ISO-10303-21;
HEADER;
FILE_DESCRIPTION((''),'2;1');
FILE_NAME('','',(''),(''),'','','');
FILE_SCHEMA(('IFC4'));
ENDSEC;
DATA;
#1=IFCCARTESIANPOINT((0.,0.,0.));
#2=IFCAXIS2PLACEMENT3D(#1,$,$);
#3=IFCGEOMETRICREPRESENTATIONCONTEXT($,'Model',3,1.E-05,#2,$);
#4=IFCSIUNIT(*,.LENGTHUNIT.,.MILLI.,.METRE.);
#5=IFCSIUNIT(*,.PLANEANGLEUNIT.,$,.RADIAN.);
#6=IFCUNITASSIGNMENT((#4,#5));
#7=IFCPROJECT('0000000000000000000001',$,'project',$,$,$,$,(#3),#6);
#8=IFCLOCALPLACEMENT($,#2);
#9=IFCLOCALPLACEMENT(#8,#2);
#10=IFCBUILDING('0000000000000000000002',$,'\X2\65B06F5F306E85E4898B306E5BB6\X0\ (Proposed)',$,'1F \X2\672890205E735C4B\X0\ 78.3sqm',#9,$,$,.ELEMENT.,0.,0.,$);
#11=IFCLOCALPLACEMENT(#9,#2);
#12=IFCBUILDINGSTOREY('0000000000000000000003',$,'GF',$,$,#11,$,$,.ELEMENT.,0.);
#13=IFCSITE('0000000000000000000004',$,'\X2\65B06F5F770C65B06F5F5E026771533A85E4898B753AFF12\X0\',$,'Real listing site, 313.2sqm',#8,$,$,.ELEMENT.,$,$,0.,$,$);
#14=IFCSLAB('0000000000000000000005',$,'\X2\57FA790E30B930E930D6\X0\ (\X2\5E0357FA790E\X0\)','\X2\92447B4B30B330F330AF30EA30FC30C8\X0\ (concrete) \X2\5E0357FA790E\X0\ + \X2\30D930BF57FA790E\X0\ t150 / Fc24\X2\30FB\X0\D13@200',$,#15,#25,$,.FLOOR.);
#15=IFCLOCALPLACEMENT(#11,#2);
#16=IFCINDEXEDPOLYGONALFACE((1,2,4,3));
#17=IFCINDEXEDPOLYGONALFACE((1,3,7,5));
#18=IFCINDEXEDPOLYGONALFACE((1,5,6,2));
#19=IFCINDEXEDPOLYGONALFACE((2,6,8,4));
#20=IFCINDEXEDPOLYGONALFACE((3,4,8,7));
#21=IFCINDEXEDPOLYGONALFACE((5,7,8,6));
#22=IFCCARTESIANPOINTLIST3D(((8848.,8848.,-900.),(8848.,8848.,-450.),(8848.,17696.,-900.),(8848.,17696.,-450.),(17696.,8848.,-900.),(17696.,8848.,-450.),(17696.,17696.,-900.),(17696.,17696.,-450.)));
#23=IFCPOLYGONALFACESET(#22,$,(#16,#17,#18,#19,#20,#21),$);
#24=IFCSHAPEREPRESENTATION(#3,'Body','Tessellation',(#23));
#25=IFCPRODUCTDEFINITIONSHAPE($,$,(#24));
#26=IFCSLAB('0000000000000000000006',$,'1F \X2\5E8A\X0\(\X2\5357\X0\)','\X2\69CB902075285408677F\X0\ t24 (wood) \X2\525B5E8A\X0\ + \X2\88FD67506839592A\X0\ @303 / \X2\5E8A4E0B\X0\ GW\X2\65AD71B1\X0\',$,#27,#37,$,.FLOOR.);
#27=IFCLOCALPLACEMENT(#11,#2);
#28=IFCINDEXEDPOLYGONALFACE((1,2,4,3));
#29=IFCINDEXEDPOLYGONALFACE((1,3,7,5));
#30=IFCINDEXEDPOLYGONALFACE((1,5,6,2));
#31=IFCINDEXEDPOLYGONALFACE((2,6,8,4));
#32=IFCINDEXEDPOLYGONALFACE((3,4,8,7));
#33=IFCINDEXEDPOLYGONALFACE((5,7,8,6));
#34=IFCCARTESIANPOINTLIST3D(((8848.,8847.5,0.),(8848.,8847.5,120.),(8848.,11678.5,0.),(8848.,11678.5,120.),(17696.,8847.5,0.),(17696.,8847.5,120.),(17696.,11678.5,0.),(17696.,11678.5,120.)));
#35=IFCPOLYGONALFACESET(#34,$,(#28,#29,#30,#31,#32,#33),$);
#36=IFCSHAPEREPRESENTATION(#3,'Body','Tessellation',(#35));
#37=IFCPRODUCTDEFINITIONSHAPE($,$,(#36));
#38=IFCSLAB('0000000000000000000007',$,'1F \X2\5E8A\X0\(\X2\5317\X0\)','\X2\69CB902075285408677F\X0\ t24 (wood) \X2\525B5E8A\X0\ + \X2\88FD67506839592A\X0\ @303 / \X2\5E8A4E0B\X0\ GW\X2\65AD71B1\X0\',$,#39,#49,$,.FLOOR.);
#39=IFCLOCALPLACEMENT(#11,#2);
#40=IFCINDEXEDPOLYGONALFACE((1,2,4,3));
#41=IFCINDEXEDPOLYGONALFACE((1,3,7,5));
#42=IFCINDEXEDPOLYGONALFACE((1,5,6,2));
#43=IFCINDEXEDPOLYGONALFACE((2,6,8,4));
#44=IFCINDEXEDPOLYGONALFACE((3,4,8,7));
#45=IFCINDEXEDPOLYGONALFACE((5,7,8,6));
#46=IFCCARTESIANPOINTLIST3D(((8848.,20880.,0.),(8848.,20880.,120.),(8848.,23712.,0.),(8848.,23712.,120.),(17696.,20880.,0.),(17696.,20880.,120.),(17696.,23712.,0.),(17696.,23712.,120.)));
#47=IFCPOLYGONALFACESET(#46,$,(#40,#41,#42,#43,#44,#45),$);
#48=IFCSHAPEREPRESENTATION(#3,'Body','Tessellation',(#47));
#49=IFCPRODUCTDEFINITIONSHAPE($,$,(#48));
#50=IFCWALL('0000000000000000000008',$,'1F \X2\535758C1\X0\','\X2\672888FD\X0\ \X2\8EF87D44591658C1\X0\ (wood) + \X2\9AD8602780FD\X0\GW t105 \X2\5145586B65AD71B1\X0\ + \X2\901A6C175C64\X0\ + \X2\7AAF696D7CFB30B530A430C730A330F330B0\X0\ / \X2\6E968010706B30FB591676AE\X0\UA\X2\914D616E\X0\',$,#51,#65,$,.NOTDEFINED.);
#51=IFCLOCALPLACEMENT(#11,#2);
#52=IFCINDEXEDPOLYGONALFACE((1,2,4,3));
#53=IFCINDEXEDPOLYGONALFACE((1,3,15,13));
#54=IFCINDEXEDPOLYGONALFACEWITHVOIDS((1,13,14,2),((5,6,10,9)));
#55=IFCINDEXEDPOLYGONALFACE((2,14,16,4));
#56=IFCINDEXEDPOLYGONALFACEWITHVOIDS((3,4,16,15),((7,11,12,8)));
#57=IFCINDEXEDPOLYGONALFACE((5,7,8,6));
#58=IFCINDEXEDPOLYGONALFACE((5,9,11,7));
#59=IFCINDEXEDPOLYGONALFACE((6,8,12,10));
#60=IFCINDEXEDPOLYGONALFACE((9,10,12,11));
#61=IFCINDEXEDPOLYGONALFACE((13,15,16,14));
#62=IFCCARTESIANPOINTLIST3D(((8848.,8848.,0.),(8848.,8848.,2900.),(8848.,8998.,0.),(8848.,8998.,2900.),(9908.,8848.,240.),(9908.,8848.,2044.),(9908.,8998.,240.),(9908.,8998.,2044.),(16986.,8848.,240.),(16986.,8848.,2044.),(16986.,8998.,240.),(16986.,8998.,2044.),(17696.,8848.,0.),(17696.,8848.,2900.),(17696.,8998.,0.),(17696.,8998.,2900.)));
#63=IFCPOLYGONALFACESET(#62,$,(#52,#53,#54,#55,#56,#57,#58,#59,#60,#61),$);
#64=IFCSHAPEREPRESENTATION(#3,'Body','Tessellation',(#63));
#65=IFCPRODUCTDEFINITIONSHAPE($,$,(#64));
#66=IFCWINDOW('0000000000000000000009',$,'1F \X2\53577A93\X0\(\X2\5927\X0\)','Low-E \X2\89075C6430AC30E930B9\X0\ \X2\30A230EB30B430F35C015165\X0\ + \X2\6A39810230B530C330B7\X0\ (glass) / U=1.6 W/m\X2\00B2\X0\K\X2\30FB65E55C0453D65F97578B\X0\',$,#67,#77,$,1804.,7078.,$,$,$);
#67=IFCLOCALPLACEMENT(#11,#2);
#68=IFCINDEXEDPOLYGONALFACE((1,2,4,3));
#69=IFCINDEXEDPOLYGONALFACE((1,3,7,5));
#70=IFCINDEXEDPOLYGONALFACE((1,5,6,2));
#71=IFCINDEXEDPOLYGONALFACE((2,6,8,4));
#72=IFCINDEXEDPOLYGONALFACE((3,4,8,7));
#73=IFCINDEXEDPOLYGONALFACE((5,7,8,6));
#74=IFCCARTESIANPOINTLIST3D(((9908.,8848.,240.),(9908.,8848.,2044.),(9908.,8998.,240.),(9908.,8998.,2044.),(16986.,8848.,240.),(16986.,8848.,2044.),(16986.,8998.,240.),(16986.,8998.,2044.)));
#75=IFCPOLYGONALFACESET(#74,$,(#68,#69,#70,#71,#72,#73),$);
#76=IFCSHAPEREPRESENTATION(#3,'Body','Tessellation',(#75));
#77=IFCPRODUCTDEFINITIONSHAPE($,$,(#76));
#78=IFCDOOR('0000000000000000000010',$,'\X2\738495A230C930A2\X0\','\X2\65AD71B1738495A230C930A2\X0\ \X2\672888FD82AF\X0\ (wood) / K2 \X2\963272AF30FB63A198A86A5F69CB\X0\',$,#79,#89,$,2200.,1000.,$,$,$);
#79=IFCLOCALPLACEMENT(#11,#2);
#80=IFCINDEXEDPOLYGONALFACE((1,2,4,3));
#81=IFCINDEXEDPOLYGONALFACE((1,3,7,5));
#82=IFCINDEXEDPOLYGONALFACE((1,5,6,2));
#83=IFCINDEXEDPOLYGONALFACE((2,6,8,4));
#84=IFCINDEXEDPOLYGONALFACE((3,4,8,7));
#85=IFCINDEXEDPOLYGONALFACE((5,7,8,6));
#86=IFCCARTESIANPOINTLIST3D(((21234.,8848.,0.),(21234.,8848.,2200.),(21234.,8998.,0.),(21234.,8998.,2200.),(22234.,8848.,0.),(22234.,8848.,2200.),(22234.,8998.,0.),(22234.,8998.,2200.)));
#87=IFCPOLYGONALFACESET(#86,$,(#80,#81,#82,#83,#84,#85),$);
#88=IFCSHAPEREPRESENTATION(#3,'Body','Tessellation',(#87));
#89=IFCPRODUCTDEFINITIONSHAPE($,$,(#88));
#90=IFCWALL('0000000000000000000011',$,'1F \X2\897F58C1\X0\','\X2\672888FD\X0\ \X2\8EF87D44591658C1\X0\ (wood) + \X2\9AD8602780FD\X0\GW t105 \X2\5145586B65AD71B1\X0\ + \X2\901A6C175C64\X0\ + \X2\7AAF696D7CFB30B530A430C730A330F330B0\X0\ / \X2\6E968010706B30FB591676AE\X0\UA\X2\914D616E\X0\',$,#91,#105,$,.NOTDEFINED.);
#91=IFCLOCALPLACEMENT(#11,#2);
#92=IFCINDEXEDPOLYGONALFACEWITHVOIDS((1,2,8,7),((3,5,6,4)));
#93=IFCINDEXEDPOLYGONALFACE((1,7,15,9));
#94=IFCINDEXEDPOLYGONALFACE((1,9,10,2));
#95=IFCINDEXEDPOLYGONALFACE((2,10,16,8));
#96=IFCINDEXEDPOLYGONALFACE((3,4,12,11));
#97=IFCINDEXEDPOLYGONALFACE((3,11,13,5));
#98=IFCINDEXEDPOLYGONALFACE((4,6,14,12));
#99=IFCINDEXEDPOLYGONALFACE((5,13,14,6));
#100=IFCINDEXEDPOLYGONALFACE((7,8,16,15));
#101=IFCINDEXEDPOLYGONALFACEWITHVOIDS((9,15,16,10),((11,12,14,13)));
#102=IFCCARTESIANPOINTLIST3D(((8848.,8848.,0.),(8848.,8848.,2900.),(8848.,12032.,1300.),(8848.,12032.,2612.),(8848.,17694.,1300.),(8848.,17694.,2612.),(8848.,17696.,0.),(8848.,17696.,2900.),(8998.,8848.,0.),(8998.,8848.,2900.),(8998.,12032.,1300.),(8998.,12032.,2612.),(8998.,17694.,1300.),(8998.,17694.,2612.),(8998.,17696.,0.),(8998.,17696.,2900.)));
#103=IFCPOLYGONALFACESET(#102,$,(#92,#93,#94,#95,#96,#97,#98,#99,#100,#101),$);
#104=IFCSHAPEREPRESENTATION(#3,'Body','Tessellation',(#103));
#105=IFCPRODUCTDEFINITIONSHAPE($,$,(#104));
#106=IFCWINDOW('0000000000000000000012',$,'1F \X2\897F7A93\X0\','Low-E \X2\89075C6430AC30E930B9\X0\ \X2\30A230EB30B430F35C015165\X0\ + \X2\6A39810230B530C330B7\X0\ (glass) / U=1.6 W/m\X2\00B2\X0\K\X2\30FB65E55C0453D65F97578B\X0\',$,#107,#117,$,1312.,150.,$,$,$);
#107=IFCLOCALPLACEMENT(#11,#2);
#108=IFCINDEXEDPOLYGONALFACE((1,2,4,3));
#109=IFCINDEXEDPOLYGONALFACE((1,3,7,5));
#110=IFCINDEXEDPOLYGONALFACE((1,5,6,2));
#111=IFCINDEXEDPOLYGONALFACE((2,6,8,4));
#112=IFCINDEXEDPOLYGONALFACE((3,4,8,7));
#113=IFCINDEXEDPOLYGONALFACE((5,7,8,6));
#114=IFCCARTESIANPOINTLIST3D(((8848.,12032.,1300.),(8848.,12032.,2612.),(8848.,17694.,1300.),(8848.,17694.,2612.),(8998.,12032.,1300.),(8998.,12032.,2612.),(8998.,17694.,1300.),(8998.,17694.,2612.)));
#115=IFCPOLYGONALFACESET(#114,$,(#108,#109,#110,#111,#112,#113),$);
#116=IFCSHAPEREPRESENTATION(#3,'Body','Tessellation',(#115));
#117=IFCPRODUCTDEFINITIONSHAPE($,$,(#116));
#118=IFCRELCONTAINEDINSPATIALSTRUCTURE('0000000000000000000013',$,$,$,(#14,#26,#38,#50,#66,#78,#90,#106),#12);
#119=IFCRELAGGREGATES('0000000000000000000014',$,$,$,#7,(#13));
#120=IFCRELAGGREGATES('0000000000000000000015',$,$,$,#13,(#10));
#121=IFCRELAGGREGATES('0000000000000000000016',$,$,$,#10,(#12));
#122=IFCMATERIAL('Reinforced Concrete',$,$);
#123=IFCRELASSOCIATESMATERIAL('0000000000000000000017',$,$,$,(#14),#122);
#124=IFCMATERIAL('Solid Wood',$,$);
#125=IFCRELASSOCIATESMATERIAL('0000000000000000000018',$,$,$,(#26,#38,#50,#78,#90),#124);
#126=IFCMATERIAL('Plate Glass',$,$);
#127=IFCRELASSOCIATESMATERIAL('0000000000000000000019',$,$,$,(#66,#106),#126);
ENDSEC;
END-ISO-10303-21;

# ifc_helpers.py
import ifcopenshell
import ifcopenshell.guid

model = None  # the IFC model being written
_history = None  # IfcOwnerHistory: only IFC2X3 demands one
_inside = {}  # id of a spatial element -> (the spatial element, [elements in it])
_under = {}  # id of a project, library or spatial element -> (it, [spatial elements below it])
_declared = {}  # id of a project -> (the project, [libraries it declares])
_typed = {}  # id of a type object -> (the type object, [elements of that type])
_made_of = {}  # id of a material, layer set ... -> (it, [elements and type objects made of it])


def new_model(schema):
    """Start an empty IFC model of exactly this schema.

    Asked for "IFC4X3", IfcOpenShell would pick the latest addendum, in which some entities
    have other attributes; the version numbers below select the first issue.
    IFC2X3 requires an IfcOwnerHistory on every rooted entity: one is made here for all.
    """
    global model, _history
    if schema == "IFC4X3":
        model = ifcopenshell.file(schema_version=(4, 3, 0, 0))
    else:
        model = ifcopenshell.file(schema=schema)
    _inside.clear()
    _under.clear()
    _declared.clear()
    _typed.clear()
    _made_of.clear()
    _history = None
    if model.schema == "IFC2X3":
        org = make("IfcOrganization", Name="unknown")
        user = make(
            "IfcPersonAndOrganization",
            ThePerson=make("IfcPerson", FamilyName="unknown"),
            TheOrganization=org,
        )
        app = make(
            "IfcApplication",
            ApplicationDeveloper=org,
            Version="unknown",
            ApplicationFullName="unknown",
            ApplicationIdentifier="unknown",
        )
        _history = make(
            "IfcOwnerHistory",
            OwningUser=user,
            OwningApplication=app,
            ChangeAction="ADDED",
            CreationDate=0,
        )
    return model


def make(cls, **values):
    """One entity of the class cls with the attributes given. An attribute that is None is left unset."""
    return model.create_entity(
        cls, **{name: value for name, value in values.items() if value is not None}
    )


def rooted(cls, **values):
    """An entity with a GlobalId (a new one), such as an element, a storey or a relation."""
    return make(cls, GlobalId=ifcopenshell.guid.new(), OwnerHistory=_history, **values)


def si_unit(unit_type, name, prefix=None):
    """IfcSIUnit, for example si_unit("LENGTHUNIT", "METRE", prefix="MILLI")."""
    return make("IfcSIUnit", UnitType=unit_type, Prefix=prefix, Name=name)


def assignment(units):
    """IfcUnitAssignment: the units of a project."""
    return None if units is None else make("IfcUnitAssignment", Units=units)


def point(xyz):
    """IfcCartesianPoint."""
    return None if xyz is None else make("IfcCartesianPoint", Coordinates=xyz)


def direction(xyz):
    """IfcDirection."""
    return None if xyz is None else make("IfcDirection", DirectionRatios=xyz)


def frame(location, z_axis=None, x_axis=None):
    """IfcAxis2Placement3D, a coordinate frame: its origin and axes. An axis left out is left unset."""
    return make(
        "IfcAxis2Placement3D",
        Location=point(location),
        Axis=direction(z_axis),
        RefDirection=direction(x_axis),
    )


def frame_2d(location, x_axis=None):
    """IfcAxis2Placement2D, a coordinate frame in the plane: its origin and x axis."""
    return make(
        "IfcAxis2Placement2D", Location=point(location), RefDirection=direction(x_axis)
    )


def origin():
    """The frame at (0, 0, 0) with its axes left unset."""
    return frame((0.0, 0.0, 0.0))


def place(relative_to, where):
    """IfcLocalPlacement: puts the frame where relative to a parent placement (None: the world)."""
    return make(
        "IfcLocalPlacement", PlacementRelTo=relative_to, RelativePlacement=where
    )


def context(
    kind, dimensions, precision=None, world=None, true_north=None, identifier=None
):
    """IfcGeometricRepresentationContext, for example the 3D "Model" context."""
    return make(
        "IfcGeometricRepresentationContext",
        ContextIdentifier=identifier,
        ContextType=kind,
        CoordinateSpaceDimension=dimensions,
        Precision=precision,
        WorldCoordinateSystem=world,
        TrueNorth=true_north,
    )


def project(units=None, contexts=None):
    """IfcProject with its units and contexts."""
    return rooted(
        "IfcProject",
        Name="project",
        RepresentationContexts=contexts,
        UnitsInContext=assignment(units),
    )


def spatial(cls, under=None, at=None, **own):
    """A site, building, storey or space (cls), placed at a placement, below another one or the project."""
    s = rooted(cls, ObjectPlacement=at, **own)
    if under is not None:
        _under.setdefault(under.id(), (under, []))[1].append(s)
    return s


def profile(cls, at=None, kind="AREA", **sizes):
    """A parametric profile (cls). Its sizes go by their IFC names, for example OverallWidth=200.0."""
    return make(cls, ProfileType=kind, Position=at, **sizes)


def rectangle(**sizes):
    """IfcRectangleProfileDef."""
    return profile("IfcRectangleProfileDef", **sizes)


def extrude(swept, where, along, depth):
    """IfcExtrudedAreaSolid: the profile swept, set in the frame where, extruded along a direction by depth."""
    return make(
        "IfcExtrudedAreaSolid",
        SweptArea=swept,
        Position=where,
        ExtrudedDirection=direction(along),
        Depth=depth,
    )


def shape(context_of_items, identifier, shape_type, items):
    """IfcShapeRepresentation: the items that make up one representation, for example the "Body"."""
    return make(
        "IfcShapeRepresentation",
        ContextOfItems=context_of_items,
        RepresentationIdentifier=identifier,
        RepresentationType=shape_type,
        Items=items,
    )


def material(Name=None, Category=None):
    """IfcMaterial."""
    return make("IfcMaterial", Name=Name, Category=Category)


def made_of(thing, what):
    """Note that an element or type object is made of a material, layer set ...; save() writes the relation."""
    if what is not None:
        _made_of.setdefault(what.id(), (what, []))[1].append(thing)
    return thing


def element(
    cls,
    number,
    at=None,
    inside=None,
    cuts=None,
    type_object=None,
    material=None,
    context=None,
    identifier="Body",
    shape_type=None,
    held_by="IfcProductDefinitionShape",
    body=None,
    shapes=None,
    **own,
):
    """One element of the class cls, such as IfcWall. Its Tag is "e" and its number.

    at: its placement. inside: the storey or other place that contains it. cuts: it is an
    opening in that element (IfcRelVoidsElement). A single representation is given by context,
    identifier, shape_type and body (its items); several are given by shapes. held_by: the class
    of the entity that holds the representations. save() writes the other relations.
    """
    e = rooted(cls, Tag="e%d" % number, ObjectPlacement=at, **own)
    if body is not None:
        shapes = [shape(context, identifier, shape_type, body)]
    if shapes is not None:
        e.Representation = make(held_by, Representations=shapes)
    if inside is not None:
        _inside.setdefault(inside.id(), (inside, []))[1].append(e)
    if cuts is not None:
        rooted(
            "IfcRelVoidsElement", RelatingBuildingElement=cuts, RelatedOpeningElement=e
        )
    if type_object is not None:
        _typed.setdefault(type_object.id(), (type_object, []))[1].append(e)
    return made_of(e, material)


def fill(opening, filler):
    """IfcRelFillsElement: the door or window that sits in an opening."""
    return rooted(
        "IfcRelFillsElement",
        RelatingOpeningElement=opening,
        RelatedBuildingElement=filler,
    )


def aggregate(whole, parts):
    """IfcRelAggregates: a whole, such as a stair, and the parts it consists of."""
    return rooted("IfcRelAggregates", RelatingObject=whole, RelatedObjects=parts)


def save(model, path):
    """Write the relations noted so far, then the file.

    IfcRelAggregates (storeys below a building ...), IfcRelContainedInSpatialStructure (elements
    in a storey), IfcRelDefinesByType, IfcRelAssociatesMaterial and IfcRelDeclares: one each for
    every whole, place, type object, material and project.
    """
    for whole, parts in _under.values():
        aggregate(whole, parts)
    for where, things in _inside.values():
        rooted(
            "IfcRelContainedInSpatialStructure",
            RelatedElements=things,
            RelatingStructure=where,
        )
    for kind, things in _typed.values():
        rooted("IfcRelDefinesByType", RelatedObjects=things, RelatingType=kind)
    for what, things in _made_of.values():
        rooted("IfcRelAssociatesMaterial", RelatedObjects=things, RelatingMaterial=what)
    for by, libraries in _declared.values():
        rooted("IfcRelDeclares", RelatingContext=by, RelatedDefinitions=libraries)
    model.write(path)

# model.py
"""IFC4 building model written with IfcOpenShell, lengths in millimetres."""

from ifc_helpers import new_model, si_unit, frame, frame_2d, origin, place, context, project, spatial, rectangle, extrude, material, element, fill, save


model = new_model("IFC4")

# Units and contexts
model_context = context("Model", 3, precision=1e-05, world=origin())
ifc_project = project(units=[si_unit("LENGTHUNIT", "METRE", prefix="MILLI"), si_unit("PLANEANGLEUNIT", "RADIAN")], contexts=[model_context])

# Site, building, storey
site_placement = place(None, origin())
site = spatial("IfcSite", under=ifc_project, at=site_placement, Name="新潟県新潟市東区藤見町２", ObjectType="Real listing site, 313.2sqm", CompositionType="ELEMENT", RefElevation=0.0)
building_placement = place(site_placement, origin())
building = spatial("IfcBuilding", under=site, at=building_placement, Name="新潟の藤見の家 (Proposed)", ObjectType="1F 木造平屋 78.3sqm", CompositionType="ELEMENT", ElevationOfRefHeight=0.0, ElevationOfTerrain=0.0)
storey_placement = place(building_placement, origin())
storey = spatial("IfcBuildingStorey", under=building, at=storey_placement, Name="GF", CompositionType="ELEMENT", Elevation=0.0)

# Slabs
ifc_material_1 = material(Name="Reinforced Concrete")
slab_1_placement = place(storey_placement, frame((4424.0, 4424.0, -450.0)))
element("IfcSlab", 1, at=slab_1_placement, inside=storey, material=ifc_material_1, Name="基礎スラブ (布基礎)", Description="鉄筋コンクリート (concrete) 布基礎 + ベタ基礎 t150 / Fc24・D13@200", PredefinedType="FLOOR", context=model_context, shape_type="SweptSolid", body=[
    extrude(rectangle(XDim=8848.0, YDim=8848.0, at=frame_2d((4424.0, 4424.0))), frame((4424.0, 4424.0, -450.0)), (0.0, 0.0, 1.0), 450.0),
])
ifc_material_2 = material(Name="Solid Wood")
slab_2_placement = place(storey_placement, frame((4424.0, 4424.0, 0.0)))
element("IfcSlab", 2, at=slab_2_placement, inside=storey, material=ifc_material_2, Name="1F 床(南)", Description="構造用合板 t24 (wood) 剛床 + 製材根太 @303 / 床下 GW断熱", PredefinedType="FLOOR", context=model_context, shape_type="SweptSolid", body=[
    extrude(rectangle(XDim=8848.0, YDim=2831.0, at=frame_2d((4424.0, 1415.0))), frame((4424.0, 4424.0, 0.0)), (0.0, 0.0, 1.0), 120.0),
])
slab_3_placement = place(storey_placement, frame((4424.0, 10440.0, 0.0)))
element("IfcSlab", 3, at=slab_3_placement, inside=storey, material=ifc_material_2, Name="1F 床(北)", Description="構造用合板 t24 (wood) 剛床 + 製材根太 @303 / 床下 GW断熱", PredefinedType="FLOOR", context=model_context, shape_type="SweptSolid", body=[
    extrude(rectangle(XDim=8848.0, YDim=2832.0, at=frame_2d((4424.0, 1416.0))), frame((4424.0, 10440.0, 0.0)), (0.0, 0.0, 1.0), 120.0),
])

# Wall, openings, window, door
wall_1_placement = place(storey_placement, frame((4424.0, 4424.0, 0.0)))
wall_1 = element("IfcWall", 4, at=wall_1_placement, inside=storey, material=ifc_material_2, Name="1F 南壁", Description="木製 軸組外壁 (wood) + 高性能GW t105 充填断熱 + 通気層 + 窯業系サイディング / 準耐火・外皮UA配慮", PredefinedType="NOTDEFINED", context=model_context, shape_type="SweptSolid", body=[
    extrude(rectangle(XDim=8848.0, YDim=150.0, at=frame_2d((4424.0, 75.0))), frame((4424.0, 4424.0, 0.0)), (0.0, 0.0, 1.0), 2900.0),
])
opening_1_placement = place(storey_placement, frame((4954.0, 4424.0, 120.0)))
opening_1 = element("IfcOpeningElement", 5, at=opening_1_placement, cuts=wall_1, PredefinedType="NOTDEFINED", context=model_context, shape_type="SweptSolid", body=[
    extrude(rectangle(XDim=7078.0, YDim=150.0, at=frame_2d((3539.0, 75.0))), frame((4954.0, 4424.0, 120.0)), (0.0, 0.0, 1.0), 1804.0),
])
opening_2_placement = place(storey_placement, frame((10617.0, 4424.0, 0.0)))
opening_2 = element("IfcOpeningElement", 6, at=opening_2_placement, cuts=wall_1, PredefinedType="NOTDEFINED", context=model_context, shape_type="SweptSolid", body=[
    extrude(rectangle(XDim=1000.0, YDim=150.0, at=frame_2d((500.0, 75.0))), frame((10617.0, 4424.0, 0.0)), (0.0, 0.0, 1.0), 2200.0),
])
ifc_material_3 = material(Name="Plate Glass")
window_1_placement = place(storey_placement, frame((4954.0, 4424.0, 120.0)))
window_1 = element("IfcWindow", 7, at=window_1_placement, inside=storey, material=ifc_material_3, Name="1F 南窓(大)", Description="Low-E 複層ガラス アルゴン封入 + 樹脂サッシ (glass) / U=1.6 W/m²K・日射取得型", OverallHeight=1804.0, OverallWidth=7078.0, context=model_context, shape_type="SweptSolid", body=[
    extrude(rectangle(XDim=7078.0, YDim=150.0, at=frame_2d((3539.0, 75.0))), frame((4954.0, 4424.0, 120.0)), (0.0, 0.0, 1.0), 1804.0),
])
fill(opening_1, window_1)
door_1_placement = place(storey_placement, frame((10617.0, 4424.0, 0.0)))
door_1 = element("IfcDoor", 8, at=door_1_placement, inside=storey, material=ifc_material_2, Name="玄関ドア", Description="断熱玄関ドア 木製芯 (wood) / K2 防犯・採風機構", OverallHeight=2200.0, OverallWidth=1000.0, context=model_context, shape_type="SweptSolid", body=[
    extrude(rectangle(XDim=1000.0, YDim=150.0, at=frame_2d((500.0, 75.0))), frame((10617.0, 4424.0, 0.0)), (0.0, 0.0, 1.0), 2200.0),
])
fill(opening_2, door_1)

# Wall, opening, window
wall_2_placement = place(storey_placement, frame((4424.0, 4424.0, 0.0)))
wall_2 = element("IfcWall", 9, at=wall_2_placement, inside=storey, material=ifc_material_2, Name="1F 西壁", Description="木製 軸組外壁 (wood) + 高性能GW t105 充填断熱 + 通気層 + 窯業系サイディング / 準耐火・外皮UA配慮", PredefinedType="NOTDEFINED", context=model_context, shape_type="SweptSolid", body=[
    extrude(rectangle(XDim=150.0, YDim=8848.0, at=frame_2d((75.0, 4424.0))), frame((4424.0, 4424.0, 0.0)), (0.0, 0.0, 1.0), 2900.0),
])
opening_3_placement = place(storey_placement, frame((4424.0, 6016.0, 650.0)))
opening_3 = element("IfcOpeningElement", 10, at=opening_3_placement, cuts=wall_2, PredefinedType="NOTDEFINED", context=model_context, shape_type="SweptSolid", body=[
    extrude(rectangle(XDim=150.0, YDim=5662.0, at=frame_2d((75.0, 2831.0))), frame((4424.0, 6016.0, 650.0)), (0.0, 0.0, 1.0), 1312.0),
])
window_2_placement = place(storey_placement, frame((4424.0, 6016.0, 650.0)))
window_2 = element("IfcWindow", 11, at=window_2_placement, inside=storey, material=ifc_material_3, Name="1F 西窓", Description="Low-E 複層ガラス アルゴン封入 + 樹脂サッシ (glass) / U=1.6 W/m²K・日射取得型", OverallHeight=1312.0, OverallWidth=150.0, context=model_context, shape_type="SweptSolid", body=[
    extrude(rectangle(XDim=150.0, YDim=5662.0, at=frame_2d((75.0, 2831.0))), frame((4424.0, 6016.0, 650.0)), (0.0, 0.0, 1.0), 1312.0),
])
fill(opening_3, window_2)

save(model, "model.ifc")
